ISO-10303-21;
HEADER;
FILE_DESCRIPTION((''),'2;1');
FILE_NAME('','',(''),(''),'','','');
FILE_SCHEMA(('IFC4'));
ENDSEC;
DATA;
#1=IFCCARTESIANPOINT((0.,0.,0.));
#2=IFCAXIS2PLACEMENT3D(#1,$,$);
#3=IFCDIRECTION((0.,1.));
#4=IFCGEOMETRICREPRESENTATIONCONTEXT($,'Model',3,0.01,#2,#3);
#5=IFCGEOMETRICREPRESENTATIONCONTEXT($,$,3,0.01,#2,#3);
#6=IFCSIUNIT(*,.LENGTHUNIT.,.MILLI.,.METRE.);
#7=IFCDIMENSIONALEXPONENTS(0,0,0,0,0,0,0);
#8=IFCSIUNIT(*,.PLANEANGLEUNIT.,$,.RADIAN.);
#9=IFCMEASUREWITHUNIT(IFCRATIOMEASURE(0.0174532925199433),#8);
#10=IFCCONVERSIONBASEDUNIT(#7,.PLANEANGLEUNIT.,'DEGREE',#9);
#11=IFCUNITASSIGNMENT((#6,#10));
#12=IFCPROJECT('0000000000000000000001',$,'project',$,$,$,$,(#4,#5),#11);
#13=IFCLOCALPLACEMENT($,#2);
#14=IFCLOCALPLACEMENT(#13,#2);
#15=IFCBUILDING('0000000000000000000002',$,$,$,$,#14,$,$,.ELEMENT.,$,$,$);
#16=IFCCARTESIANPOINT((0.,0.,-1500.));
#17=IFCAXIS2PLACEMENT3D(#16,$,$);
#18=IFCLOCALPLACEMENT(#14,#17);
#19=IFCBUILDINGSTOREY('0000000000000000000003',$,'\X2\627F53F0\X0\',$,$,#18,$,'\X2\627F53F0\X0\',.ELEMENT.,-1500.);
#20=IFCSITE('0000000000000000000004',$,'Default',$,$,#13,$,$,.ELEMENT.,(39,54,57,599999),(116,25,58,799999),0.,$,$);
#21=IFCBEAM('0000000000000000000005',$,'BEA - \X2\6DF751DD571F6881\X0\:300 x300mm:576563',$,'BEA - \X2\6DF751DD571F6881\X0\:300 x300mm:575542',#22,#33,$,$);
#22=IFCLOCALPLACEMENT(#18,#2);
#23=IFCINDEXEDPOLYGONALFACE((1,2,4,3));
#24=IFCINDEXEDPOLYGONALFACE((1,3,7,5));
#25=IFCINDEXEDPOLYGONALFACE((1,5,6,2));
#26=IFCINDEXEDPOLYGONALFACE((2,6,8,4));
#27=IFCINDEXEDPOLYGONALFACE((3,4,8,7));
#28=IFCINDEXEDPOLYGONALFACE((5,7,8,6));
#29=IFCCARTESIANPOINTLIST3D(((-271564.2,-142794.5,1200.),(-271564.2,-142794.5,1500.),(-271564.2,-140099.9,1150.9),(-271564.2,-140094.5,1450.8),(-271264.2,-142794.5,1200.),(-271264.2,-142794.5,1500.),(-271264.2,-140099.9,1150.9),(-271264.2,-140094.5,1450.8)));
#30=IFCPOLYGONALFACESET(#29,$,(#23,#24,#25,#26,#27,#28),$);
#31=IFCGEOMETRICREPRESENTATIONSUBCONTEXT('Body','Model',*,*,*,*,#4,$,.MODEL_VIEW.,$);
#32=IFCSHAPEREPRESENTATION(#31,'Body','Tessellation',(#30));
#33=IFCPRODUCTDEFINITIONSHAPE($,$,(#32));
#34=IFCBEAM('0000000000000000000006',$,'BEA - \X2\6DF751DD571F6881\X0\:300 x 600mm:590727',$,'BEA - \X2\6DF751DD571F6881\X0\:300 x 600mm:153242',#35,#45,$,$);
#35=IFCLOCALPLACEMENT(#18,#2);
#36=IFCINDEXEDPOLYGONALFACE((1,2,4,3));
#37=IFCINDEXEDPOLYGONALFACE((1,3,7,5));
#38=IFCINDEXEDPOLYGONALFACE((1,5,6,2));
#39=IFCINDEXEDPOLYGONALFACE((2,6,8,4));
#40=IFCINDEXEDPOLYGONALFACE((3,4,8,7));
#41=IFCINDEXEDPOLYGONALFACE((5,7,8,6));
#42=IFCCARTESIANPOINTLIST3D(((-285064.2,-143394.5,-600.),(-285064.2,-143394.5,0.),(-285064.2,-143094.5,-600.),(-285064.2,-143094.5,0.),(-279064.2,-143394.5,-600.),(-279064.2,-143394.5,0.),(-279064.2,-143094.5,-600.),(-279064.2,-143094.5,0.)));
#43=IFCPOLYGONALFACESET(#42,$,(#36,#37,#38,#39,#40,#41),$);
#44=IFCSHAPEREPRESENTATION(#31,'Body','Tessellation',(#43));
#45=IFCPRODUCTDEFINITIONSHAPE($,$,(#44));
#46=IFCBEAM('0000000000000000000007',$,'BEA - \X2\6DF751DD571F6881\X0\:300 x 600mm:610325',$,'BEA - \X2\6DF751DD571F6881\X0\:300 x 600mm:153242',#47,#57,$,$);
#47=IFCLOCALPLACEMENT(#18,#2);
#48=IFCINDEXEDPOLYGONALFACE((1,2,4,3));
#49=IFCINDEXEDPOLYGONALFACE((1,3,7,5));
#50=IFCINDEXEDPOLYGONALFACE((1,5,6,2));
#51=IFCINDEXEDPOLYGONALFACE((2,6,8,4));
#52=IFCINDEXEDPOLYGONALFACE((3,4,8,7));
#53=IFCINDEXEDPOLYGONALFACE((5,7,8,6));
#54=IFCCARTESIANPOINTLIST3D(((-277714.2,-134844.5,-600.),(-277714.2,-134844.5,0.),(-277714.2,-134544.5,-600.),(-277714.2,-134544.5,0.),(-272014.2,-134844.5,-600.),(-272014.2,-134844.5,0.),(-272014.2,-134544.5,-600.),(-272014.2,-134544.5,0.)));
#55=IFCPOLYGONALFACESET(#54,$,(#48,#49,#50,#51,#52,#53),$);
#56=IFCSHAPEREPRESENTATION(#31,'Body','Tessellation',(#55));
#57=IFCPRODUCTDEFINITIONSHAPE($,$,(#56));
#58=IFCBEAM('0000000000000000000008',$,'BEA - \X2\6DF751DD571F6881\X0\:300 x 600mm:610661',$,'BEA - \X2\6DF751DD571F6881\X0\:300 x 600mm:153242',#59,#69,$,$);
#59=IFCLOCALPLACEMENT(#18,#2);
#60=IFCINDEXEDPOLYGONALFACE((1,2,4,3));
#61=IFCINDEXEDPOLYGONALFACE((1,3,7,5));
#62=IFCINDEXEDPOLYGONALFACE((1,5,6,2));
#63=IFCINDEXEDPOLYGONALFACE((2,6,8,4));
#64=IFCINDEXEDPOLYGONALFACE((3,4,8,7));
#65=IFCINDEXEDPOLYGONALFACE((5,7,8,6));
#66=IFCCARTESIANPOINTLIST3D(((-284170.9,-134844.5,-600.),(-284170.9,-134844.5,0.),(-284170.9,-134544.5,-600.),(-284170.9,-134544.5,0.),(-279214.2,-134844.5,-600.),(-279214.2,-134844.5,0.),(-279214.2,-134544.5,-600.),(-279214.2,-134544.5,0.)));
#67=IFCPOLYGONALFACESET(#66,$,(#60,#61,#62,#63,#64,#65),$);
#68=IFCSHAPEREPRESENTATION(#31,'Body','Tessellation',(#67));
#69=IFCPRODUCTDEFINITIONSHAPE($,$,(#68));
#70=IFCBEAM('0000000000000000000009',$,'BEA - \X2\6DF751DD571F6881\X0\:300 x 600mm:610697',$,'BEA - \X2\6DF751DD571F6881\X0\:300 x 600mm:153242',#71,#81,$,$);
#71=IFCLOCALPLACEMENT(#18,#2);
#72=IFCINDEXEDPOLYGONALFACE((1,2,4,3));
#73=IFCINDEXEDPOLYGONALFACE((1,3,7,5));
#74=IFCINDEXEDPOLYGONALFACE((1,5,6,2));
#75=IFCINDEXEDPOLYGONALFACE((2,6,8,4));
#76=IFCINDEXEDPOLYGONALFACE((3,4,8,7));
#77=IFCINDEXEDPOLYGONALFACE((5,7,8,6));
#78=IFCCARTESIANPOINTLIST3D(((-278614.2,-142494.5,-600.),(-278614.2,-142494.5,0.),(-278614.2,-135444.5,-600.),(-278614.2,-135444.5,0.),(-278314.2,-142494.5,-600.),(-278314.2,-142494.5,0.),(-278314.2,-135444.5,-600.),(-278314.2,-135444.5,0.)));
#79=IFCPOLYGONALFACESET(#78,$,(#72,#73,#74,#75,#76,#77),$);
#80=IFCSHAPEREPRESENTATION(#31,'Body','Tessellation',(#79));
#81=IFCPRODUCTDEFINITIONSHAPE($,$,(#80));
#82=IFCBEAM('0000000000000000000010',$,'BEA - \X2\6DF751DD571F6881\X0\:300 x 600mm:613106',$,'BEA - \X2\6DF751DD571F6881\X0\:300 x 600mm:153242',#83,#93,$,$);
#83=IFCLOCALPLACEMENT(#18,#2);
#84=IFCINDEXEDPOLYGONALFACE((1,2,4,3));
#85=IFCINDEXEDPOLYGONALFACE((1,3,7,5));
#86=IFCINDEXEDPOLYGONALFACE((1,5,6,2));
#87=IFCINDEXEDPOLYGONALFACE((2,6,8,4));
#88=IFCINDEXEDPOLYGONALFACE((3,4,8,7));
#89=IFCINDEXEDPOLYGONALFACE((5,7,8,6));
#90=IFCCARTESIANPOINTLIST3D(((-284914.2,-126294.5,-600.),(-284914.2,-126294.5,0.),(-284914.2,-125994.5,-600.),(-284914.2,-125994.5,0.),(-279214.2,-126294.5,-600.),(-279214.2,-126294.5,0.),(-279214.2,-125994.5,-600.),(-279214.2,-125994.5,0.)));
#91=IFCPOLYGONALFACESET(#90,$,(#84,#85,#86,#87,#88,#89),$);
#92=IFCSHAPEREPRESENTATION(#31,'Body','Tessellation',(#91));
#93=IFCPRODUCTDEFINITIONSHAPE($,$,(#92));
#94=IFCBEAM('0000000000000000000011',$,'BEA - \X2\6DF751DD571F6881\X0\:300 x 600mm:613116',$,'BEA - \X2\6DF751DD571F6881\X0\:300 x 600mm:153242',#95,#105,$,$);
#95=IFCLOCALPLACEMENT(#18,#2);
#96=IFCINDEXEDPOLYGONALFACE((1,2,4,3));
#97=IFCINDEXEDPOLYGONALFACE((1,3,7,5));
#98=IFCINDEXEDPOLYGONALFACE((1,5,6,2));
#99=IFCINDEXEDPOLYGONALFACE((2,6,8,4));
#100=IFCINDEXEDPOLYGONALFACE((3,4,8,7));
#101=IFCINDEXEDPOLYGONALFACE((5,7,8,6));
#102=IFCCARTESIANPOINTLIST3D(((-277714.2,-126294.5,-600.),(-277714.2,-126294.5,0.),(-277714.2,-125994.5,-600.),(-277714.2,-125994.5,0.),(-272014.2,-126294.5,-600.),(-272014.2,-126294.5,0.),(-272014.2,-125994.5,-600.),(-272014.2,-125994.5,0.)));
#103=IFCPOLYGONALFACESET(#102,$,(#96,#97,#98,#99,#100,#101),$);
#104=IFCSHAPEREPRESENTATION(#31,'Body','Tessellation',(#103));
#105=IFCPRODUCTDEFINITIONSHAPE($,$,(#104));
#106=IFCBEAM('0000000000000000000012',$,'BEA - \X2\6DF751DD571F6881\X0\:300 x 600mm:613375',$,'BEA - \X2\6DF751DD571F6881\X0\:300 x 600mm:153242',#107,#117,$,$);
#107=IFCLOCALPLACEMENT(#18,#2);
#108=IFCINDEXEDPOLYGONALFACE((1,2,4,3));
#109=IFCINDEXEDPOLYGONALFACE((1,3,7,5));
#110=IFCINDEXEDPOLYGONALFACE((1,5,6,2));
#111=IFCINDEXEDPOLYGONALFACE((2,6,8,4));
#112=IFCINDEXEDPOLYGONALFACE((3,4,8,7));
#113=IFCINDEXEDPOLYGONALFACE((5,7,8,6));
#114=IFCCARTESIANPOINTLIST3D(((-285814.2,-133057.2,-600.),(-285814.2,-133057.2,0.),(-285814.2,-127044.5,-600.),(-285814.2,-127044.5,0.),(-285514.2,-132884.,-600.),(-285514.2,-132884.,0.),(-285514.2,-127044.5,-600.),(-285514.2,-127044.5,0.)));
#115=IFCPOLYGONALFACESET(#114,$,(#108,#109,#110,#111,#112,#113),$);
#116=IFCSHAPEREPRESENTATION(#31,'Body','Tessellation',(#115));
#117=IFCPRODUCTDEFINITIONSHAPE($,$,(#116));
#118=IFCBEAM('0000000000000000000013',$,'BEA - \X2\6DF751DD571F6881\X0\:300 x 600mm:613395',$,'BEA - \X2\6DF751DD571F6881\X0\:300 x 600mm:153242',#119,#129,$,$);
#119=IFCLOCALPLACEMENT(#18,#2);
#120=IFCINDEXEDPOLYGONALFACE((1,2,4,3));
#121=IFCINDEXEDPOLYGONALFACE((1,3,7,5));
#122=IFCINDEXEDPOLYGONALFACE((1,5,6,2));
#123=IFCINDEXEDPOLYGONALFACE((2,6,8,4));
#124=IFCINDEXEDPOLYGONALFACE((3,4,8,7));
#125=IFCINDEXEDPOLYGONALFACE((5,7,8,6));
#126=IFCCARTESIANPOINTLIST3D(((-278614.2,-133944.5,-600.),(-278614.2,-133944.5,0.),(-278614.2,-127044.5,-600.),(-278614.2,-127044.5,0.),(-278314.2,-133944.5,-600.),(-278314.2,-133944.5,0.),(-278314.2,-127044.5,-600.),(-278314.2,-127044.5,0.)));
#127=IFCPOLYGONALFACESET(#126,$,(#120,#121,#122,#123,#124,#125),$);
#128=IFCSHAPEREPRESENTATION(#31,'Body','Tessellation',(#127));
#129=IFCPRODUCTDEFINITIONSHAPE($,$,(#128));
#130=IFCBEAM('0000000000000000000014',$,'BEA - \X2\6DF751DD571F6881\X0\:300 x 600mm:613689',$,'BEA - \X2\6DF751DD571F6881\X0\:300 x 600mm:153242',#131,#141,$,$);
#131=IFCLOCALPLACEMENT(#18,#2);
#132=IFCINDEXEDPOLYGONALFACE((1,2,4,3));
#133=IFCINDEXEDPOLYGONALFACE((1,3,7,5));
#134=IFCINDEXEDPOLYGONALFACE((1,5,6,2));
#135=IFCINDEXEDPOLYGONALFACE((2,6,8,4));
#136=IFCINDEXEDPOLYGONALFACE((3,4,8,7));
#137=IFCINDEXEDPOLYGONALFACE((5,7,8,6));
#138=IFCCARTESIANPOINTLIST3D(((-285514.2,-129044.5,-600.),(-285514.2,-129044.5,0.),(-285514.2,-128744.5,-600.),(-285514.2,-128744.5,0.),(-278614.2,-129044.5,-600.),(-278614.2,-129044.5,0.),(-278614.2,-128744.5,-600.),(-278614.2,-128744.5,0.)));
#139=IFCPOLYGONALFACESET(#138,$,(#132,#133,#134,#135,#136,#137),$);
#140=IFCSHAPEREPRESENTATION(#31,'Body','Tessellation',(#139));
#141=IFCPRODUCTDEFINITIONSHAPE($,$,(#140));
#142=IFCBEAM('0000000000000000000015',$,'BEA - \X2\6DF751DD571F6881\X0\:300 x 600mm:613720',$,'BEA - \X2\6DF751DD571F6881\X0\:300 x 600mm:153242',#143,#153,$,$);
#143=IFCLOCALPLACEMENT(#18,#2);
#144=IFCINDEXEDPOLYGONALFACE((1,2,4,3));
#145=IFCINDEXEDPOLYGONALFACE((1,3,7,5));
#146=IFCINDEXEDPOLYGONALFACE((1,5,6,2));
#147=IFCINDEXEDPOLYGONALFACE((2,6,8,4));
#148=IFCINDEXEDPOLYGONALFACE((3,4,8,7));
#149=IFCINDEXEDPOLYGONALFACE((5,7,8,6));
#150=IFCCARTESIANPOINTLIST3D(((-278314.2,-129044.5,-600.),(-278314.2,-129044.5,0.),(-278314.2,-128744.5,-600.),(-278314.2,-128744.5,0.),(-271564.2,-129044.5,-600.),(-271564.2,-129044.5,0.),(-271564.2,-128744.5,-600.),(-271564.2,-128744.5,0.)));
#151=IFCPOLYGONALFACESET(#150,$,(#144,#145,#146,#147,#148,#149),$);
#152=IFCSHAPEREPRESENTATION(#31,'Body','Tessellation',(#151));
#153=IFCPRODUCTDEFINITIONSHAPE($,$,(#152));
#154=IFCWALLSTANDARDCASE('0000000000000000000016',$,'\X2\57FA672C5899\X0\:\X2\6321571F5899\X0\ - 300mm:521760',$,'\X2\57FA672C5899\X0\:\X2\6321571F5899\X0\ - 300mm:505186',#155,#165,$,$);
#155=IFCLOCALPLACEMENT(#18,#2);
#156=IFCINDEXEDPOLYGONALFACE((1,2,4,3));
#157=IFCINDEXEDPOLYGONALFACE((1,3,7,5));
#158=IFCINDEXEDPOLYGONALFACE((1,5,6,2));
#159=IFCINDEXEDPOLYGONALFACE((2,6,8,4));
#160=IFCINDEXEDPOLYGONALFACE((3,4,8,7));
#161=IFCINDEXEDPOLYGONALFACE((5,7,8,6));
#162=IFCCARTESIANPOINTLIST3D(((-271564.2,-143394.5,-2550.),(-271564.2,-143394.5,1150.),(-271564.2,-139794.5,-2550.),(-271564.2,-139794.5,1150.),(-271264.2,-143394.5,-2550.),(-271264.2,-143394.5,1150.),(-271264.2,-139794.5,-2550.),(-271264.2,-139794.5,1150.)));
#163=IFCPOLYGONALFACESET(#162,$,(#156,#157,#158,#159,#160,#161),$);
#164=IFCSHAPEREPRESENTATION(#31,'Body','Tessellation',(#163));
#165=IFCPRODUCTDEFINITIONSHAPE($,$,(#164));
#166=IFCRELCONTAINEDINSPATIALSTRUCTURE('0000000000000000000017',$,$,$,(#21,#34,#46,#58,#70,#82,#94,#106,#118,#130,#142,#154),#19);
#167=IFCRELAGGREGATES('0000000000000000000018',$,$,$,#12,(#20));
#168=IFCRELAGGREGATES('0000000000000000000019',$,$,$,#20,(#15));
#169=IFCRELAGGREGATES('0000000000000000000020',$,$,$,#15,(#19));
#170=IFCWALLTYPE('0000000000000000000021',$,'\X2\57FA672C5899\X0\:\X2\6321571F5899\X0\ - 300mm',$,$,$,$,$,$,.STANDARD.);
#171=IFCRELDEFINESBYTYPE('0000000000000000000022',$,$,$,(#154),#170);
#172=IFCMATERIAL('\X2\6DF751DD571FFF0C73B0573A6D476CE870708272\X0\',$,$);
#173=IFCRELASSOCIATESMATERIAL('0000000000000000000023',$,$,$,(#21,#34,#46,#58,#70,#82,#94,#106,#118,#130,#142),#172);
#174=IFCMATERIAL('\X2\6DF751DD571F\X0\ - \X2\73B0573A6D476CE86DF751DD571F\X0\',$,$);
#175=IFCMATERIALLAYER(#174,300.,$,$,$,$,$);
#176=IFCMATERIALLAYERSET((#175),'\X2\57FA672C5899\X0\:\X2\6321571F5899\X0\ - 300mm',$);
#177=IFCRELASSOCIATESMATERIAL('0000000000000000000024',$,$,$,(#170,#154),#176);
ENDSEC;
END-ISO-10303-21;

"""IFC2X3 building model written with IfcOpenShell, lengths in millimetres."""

from ifc_helpers import new_model, entity, si_unit, converted_unit, direction, frame, frame_2d, origin, origin_2d_with_axis, place, context, subcontext, project, spatial, rectangle, extrude, clip, halfspace, material, layer, layer_set, layer_usage, type_object, element, save


model = new_model("IFC2X3")

# Units and contexts
model_context = context("Model", 3, precision=0.01, world=origin(), true_north=direction((0.0, 1.0)))
context_of_model = context(None, 3, precision=0.01, world=origin(), true_north=direction((0.0, 1.0)))
body_context = subcontext(model_context, "Body", "Model", "MODEL_VIEW")
ifc_project = project(units=[si_unit("LENGTHUNIT", "METRE", prefix="MILLI"), converted_unit("PLANEANGLEUNIT", "DEGREE", entity("IfcRatioMeasure", 0.0174532925199433), si_unit("PLANEANGLEUNIT", "RADIAN"), dimensions=[0, 0, 0, 0, 0, 0, 0])], contexts=[model_context, context_of_model])

# Site, building, storey
site_placement = place(None, origin())
site = spatial("IfcSite", under=ifc_project, at=site_placement, Name="Default", CompositionType="ELEMENT", RefLatitude=(39, 54, 57, 599999), RefLongitude=(116, 25, 58, 799999), RefElevation=0.0)
building_placement = place(site_placement, origin())
building = spatial("IfcBuilding", under=site, at=building_placement, CompositionType="ELEMENT")
storey_placement = place(building_placement, frame((0.0, 0.0, -1500.0)))
storey = spatial("IfcBuildingStorey", under=building, at=storey_placement, Name="承台", LongName="承台", CompositionType="ELEMENT", Elevation=-1500.0)

# Shared definitions
ifc_material_1 = material(Name="混凝土 - 现场浇注混凝土")

# Shared definitions
ifc_material_2 = material(Name="混凝土，现场浇注灰色")

# Beams
beam_1_placement = place(storey_placement, frame((-271414.2, -140094.5, 1450.8), z_axis=(0.0, 0.018213, 0.999834), x_axis=(0.0, -0.999834, 0.018213)))
element("IfcBeam", 1, at=beam_1_placement, inside=storey, material=ifc_material_2, Name="BEA - 混凝土梁:300 x300mm:576563", ObjectType="BEA - 混凝土梁:300 x300mm:575542", context=body_context, shape_type="Clipping", body=[
    clip(extrude(rectangle(XDim=300.0, YDim=300.0, at=frame_2d((0.0, 0.0), x_axis=(1.0, 0.0))), frame((0.0, 0.0, -150.0), z_axis=(1.0, 0.0, 0.0), x_axis=(0.0, 0.0, -1.0)), (0.0, 0.0, 1.0), 2700.4), halfspace(frame((2700.4, 450.0, 0.0), z_axis=(0.999834, 0.0, -0.018213), x_axis=(-0.018213, 0.0, -0.999834)), False)),
])
beam_2_placement = place(storey_placement, frame((-279064.2, -143244.5, 0.0), z_axis=(0.0, 0.0, 1.0), x_axis=(-1.0, 0.0, 0.0)))
element("IfcBeam", 2, at=beam_2_placement, inside=storey, material=ifc_material_2, Name="BEA - 混凝土梁:300 x 600mm:590727", ObjectType="BEA - 混凝土梁:300 x 600mm:153242", context=body_context, shape_type="SweptSolid", body=[
    extrude(rectangle(XDim=600.0, YDim=300.0, at=frame_2d((0.0, 0.0), x_axis=(1.0, 0.0))), frame((0.0, 0.0, -300.0), z_axis=(1.0, 0.0, 0.0), x_axis=(0.0, 0.0, -1.0)), (0.0, 0.0, 1.0), 6000.0),
])
beam_3_placement = place(storey_placement, frame((-272014.2, -134694.5, 0.0), z_axis=(0.0, 0.0, 1.0), x_axis=(-1.0, 0.0, 0.0)))
element("IfcBeam", 3, at=beam_3_placement, inside=storey, material=ifc_material_2, Name="BEA - 混凝土梁:300 x 600mm:610325", ObjectType="BEA - 混凝土梁:300 x 600mm:153242", context=body_context, shape_type="SweptSolid", body=[
    extrude(rectangle(XDim=600.0, YDim=300.0, at=frame_2d((0.0, 0.0), x_axis=(1.0, 0.0))), frame((0.0, 0.0, -300.0), z_axis=(1.0, 0.0, 0.0), x_axis=(0.0, 0.0, -1.0)), (0.0, 0.0, 1.0), 5700.0),
])
beam_4_placement = place(storey_placement, frame((-279214.2, -134694.5, 0.0), z_axis=(0.0, 0.0, 1.0), x_axis=(-1.0, 0.0, 0.0)))
element("IfcBeam", 4, at=beam_4_placement, inside=storey, material=ifc_material_2, Name="BEA - 混凝土梁:300 x 600mm:610661", ObjectType="BEA - 混凝土梁:300 x 600mm:153242", context=body_context, shape_type="SweptSolid", body=[
    extrude(rectangle(XDim=600.0, YDim=300.0, at=frame_2d((0.0, 0.0), x_axis=(1.0, 0.0))), frame((0.0, 0.0, -300.0), z_axis=(1.0, 0.0, 0.0), x_axis=(0.0, 0.0, -1.0)), (0.0, 0.0, 1.0), 4956.7),
])
beam_5_placement = place(storey_placement, frame((-278464.2, -135444.5, 0.0), z_axis=(0.0, 0.0, 1.0), x_axis=(0.0, -1.0, 0.0)))
element("IfcBeam", 5, at=beam_5_placement, inside=storey, material=ifc_material_2, Name="BEA - 混凝土梁:300 x 600mm:610697", ObjectType="BEA - 混凝土梁:300 x 600mm:153242", context=body_context, shape_type="SweptSolid", body=[
    extrude(rectangle(XDim=600.0, YDim=300.0, at=origin_2d_with_axis()), frame((0.0, 0.0, -300.0), z_axis=(1.0, 0.0, 0.0), x_axis=(0.0, 0.0, -1.0)), (0.0, 0.0, 1.0), 7050.0),
])
for number, where, z_axis, x_axis, name in (
    (6, (-279214.2, -126144.5, 0.0), (0.0, 0.0, 1.0), (-1.0, 0.0, 0.0), "BEA - 混凝土梁:300 x 600mm:613106"),
    (7, (-272014.2, -126144.5, 0.0), (0.0, 0.0, 1.0), (-1.0, 0.0, 0.0), "BEA - 混凝土梁:300 x 600mm:613116"),
):
    element("IfcBeam", number, at=place(storey_placement, frame(where, z_axis=z_axis, x_axis=x_axis)), inside=storey, material=ifc_material_2, Name=name, ObjectType="BEA - 混凝土梁:300 x 600mm:153242", context=body_context, shape_type="SweptSolid", body=[
        extrude(rectangle(XDim=600.0, YDim=300.0, at=frame_2d((0.0, 0.0), x_axis=(1.0, 0.0))), frame((0.0, 0.0, -300.0), z_axis=(1.0, 0.0, 0.0), x_axis=(0.0, 0.0, -1.0)), (0.0, 0.0, 1.0), 5700.0),
    ])
beam_6_placement = place(storey_placement, frame((-285664.2, -127044.5, 0.0), z_axis=(0.0, 0.0, 1.0), x_axis=(0.0, -1.0, 0.0)))
element("IfcBeam", 8, at=beam_6_placement, inside=storey, material=ifc_material_2, Name="BEA - 混凝土梁:300 x 600mm:613375", ObjectType="BEA - 混凝土梁:300 x 600mm:153242", context=body_context, shape_type="Clipping", body=[
    clip(extrude(rectangle(XDim=600.0, YDim=300.0, at=frame_2d((0.0, 0.0), x_axis=(1.0, 0.0))), frame((0.0, 0.0, -300.0), z_axis=(1.0, 0.0, 0.0), x_axis=(0.0, 0.0, -1.0)), (0.0, 0.0, 1.0), 6012.7), halfspace(frame((5526.0, 693.3, 0.0), z_axis=(0.866125, 0.499827, 0.0), x_axis=(-0.499827, 0.866125, 0.0)), False)),
])
beam_7_placement = place(storey_placement, frame((-278464.2, -127044.5, 0.0), z_axis=(0.0, 0.0, 1.0), x_axis=(0.0, -1.0, 0.0)))
element("IfcBeam", 9, at=beam_7_placement, inside=storey, material=ifc_material_2, Name="BEA - 混凝土梁:300 x 600mm:613395", ObjectType="BEA - 混凝土梁:300 x 600mm:153242", context=body_context, shape_type="SweptSolid", body=[
    extrude(rectangle(XDim=600.0, YDim=300.0, at=origin_2d_with_axis()), frame((0.0, 0.0, -300.0), z_axis=(1.0, 0.0, 0.0), x_axis=(0.0, 0.0, -1.0)), (0.0, 0.0, 1.0), 6900.0),
])
beam_8_placement = place(storey_placement, frame((-278614.2, -128894.5, 0.0), z_axis=(0.0, 0.0, 1.0), x_axis=(-1.0, 0.0, 0.0)))
element("IfcBeam", 10, at=beam_8_placement, inside=storey, material=ifc_material_2, Name="BEA - 混凝土梁:300 x 600mm:613689", ObjectType="BEA - 混凝土梁:300 x 600mm:153242", context=body_context, shape_type="SweptSolid", body=[
    extrude(rectangle(XDim=600.0, YDim=300.0, at=frame_2d((0.0, 0.0), x_axis=(1.0, 0.0))), frame((0.0, 0.0, -300.0), z_axis=(1.0, 0.0, 0.0), x_axis=(0.0, 0.0, -1.0)), (0.0, 0.0, 1.0), 6900.0),
])
beam_9_placement = place(storey_placement, frame((-271564.2, -128894.5, 0.0), z_axis=(0.0, 0.0, 1.0), x_axis=(-1.0, 0.0, 0.0)))
element("IfcBeam", 11, at=beam_9_placement, inside=storey, material=ifc_material_2, Name="BEA - 混凝土梁:300 x 600mm:613720", ObjectType="BEA - 混凝土梁:300 x 600mm:153242", context=body_context, shape_type="SweptSolid", body=[
    extrude(rectangle(XDim=600.0, YDim=300.0, at=frame_2d((0.0, 0.0), x_axis=(1.0, 0.0))), frame((0.0, 0.0, -300.0), z_axis=(1.0, 0.0, 0.0), x_axis=(0.0, 0.0, -1.0)), (0.0, 0.0, 1.0), 6750.0),
])

# Wall
ifc_layer_1 = layer(ifc_material_1, 300.0)
ifc_layer_set_1 = layer_set([ifc_layer_1], Name="基本墙:挡土墙 - 300mm")
ifc_layer_usage_1 = layer_usage(ifc_layer_set_1, "AXIS2", "NEGATIVE", 150.0)
wall_type = type_object("IfcWallType", Name="基本墙:挡土墙 - 300mm", PredefinedType="STANDARD", material=ifc_layer_set_1)
wall_placement = place(storey_placement, frame((-271414.2, -139794.5, -2550.0), z_axis=(0.0, 0.0, 1.0), x_axis=(0.0, -1.0, 0.0)))
element("IfcWallStandardCase", 12, at=wall_placement, inside=storey, type_object=wall_type, material=ifc_layer_usage_1, Name="基本墙:挡土墙 - 300mm:521760", ObjectType="基本墙:挡土墙 - 300mm:505186", context=body_context, shape_type="SweptSolid", body=[
    extrude(rectangle(XDim=3600.0, YDim=300.0, at=frame_2d((1800.0, 0.0), x_axis=(-1.0, 0.0))), origin(), (0.0, 0.0, 1.0), 3700.0),
])

save(model, "model.ifc")
